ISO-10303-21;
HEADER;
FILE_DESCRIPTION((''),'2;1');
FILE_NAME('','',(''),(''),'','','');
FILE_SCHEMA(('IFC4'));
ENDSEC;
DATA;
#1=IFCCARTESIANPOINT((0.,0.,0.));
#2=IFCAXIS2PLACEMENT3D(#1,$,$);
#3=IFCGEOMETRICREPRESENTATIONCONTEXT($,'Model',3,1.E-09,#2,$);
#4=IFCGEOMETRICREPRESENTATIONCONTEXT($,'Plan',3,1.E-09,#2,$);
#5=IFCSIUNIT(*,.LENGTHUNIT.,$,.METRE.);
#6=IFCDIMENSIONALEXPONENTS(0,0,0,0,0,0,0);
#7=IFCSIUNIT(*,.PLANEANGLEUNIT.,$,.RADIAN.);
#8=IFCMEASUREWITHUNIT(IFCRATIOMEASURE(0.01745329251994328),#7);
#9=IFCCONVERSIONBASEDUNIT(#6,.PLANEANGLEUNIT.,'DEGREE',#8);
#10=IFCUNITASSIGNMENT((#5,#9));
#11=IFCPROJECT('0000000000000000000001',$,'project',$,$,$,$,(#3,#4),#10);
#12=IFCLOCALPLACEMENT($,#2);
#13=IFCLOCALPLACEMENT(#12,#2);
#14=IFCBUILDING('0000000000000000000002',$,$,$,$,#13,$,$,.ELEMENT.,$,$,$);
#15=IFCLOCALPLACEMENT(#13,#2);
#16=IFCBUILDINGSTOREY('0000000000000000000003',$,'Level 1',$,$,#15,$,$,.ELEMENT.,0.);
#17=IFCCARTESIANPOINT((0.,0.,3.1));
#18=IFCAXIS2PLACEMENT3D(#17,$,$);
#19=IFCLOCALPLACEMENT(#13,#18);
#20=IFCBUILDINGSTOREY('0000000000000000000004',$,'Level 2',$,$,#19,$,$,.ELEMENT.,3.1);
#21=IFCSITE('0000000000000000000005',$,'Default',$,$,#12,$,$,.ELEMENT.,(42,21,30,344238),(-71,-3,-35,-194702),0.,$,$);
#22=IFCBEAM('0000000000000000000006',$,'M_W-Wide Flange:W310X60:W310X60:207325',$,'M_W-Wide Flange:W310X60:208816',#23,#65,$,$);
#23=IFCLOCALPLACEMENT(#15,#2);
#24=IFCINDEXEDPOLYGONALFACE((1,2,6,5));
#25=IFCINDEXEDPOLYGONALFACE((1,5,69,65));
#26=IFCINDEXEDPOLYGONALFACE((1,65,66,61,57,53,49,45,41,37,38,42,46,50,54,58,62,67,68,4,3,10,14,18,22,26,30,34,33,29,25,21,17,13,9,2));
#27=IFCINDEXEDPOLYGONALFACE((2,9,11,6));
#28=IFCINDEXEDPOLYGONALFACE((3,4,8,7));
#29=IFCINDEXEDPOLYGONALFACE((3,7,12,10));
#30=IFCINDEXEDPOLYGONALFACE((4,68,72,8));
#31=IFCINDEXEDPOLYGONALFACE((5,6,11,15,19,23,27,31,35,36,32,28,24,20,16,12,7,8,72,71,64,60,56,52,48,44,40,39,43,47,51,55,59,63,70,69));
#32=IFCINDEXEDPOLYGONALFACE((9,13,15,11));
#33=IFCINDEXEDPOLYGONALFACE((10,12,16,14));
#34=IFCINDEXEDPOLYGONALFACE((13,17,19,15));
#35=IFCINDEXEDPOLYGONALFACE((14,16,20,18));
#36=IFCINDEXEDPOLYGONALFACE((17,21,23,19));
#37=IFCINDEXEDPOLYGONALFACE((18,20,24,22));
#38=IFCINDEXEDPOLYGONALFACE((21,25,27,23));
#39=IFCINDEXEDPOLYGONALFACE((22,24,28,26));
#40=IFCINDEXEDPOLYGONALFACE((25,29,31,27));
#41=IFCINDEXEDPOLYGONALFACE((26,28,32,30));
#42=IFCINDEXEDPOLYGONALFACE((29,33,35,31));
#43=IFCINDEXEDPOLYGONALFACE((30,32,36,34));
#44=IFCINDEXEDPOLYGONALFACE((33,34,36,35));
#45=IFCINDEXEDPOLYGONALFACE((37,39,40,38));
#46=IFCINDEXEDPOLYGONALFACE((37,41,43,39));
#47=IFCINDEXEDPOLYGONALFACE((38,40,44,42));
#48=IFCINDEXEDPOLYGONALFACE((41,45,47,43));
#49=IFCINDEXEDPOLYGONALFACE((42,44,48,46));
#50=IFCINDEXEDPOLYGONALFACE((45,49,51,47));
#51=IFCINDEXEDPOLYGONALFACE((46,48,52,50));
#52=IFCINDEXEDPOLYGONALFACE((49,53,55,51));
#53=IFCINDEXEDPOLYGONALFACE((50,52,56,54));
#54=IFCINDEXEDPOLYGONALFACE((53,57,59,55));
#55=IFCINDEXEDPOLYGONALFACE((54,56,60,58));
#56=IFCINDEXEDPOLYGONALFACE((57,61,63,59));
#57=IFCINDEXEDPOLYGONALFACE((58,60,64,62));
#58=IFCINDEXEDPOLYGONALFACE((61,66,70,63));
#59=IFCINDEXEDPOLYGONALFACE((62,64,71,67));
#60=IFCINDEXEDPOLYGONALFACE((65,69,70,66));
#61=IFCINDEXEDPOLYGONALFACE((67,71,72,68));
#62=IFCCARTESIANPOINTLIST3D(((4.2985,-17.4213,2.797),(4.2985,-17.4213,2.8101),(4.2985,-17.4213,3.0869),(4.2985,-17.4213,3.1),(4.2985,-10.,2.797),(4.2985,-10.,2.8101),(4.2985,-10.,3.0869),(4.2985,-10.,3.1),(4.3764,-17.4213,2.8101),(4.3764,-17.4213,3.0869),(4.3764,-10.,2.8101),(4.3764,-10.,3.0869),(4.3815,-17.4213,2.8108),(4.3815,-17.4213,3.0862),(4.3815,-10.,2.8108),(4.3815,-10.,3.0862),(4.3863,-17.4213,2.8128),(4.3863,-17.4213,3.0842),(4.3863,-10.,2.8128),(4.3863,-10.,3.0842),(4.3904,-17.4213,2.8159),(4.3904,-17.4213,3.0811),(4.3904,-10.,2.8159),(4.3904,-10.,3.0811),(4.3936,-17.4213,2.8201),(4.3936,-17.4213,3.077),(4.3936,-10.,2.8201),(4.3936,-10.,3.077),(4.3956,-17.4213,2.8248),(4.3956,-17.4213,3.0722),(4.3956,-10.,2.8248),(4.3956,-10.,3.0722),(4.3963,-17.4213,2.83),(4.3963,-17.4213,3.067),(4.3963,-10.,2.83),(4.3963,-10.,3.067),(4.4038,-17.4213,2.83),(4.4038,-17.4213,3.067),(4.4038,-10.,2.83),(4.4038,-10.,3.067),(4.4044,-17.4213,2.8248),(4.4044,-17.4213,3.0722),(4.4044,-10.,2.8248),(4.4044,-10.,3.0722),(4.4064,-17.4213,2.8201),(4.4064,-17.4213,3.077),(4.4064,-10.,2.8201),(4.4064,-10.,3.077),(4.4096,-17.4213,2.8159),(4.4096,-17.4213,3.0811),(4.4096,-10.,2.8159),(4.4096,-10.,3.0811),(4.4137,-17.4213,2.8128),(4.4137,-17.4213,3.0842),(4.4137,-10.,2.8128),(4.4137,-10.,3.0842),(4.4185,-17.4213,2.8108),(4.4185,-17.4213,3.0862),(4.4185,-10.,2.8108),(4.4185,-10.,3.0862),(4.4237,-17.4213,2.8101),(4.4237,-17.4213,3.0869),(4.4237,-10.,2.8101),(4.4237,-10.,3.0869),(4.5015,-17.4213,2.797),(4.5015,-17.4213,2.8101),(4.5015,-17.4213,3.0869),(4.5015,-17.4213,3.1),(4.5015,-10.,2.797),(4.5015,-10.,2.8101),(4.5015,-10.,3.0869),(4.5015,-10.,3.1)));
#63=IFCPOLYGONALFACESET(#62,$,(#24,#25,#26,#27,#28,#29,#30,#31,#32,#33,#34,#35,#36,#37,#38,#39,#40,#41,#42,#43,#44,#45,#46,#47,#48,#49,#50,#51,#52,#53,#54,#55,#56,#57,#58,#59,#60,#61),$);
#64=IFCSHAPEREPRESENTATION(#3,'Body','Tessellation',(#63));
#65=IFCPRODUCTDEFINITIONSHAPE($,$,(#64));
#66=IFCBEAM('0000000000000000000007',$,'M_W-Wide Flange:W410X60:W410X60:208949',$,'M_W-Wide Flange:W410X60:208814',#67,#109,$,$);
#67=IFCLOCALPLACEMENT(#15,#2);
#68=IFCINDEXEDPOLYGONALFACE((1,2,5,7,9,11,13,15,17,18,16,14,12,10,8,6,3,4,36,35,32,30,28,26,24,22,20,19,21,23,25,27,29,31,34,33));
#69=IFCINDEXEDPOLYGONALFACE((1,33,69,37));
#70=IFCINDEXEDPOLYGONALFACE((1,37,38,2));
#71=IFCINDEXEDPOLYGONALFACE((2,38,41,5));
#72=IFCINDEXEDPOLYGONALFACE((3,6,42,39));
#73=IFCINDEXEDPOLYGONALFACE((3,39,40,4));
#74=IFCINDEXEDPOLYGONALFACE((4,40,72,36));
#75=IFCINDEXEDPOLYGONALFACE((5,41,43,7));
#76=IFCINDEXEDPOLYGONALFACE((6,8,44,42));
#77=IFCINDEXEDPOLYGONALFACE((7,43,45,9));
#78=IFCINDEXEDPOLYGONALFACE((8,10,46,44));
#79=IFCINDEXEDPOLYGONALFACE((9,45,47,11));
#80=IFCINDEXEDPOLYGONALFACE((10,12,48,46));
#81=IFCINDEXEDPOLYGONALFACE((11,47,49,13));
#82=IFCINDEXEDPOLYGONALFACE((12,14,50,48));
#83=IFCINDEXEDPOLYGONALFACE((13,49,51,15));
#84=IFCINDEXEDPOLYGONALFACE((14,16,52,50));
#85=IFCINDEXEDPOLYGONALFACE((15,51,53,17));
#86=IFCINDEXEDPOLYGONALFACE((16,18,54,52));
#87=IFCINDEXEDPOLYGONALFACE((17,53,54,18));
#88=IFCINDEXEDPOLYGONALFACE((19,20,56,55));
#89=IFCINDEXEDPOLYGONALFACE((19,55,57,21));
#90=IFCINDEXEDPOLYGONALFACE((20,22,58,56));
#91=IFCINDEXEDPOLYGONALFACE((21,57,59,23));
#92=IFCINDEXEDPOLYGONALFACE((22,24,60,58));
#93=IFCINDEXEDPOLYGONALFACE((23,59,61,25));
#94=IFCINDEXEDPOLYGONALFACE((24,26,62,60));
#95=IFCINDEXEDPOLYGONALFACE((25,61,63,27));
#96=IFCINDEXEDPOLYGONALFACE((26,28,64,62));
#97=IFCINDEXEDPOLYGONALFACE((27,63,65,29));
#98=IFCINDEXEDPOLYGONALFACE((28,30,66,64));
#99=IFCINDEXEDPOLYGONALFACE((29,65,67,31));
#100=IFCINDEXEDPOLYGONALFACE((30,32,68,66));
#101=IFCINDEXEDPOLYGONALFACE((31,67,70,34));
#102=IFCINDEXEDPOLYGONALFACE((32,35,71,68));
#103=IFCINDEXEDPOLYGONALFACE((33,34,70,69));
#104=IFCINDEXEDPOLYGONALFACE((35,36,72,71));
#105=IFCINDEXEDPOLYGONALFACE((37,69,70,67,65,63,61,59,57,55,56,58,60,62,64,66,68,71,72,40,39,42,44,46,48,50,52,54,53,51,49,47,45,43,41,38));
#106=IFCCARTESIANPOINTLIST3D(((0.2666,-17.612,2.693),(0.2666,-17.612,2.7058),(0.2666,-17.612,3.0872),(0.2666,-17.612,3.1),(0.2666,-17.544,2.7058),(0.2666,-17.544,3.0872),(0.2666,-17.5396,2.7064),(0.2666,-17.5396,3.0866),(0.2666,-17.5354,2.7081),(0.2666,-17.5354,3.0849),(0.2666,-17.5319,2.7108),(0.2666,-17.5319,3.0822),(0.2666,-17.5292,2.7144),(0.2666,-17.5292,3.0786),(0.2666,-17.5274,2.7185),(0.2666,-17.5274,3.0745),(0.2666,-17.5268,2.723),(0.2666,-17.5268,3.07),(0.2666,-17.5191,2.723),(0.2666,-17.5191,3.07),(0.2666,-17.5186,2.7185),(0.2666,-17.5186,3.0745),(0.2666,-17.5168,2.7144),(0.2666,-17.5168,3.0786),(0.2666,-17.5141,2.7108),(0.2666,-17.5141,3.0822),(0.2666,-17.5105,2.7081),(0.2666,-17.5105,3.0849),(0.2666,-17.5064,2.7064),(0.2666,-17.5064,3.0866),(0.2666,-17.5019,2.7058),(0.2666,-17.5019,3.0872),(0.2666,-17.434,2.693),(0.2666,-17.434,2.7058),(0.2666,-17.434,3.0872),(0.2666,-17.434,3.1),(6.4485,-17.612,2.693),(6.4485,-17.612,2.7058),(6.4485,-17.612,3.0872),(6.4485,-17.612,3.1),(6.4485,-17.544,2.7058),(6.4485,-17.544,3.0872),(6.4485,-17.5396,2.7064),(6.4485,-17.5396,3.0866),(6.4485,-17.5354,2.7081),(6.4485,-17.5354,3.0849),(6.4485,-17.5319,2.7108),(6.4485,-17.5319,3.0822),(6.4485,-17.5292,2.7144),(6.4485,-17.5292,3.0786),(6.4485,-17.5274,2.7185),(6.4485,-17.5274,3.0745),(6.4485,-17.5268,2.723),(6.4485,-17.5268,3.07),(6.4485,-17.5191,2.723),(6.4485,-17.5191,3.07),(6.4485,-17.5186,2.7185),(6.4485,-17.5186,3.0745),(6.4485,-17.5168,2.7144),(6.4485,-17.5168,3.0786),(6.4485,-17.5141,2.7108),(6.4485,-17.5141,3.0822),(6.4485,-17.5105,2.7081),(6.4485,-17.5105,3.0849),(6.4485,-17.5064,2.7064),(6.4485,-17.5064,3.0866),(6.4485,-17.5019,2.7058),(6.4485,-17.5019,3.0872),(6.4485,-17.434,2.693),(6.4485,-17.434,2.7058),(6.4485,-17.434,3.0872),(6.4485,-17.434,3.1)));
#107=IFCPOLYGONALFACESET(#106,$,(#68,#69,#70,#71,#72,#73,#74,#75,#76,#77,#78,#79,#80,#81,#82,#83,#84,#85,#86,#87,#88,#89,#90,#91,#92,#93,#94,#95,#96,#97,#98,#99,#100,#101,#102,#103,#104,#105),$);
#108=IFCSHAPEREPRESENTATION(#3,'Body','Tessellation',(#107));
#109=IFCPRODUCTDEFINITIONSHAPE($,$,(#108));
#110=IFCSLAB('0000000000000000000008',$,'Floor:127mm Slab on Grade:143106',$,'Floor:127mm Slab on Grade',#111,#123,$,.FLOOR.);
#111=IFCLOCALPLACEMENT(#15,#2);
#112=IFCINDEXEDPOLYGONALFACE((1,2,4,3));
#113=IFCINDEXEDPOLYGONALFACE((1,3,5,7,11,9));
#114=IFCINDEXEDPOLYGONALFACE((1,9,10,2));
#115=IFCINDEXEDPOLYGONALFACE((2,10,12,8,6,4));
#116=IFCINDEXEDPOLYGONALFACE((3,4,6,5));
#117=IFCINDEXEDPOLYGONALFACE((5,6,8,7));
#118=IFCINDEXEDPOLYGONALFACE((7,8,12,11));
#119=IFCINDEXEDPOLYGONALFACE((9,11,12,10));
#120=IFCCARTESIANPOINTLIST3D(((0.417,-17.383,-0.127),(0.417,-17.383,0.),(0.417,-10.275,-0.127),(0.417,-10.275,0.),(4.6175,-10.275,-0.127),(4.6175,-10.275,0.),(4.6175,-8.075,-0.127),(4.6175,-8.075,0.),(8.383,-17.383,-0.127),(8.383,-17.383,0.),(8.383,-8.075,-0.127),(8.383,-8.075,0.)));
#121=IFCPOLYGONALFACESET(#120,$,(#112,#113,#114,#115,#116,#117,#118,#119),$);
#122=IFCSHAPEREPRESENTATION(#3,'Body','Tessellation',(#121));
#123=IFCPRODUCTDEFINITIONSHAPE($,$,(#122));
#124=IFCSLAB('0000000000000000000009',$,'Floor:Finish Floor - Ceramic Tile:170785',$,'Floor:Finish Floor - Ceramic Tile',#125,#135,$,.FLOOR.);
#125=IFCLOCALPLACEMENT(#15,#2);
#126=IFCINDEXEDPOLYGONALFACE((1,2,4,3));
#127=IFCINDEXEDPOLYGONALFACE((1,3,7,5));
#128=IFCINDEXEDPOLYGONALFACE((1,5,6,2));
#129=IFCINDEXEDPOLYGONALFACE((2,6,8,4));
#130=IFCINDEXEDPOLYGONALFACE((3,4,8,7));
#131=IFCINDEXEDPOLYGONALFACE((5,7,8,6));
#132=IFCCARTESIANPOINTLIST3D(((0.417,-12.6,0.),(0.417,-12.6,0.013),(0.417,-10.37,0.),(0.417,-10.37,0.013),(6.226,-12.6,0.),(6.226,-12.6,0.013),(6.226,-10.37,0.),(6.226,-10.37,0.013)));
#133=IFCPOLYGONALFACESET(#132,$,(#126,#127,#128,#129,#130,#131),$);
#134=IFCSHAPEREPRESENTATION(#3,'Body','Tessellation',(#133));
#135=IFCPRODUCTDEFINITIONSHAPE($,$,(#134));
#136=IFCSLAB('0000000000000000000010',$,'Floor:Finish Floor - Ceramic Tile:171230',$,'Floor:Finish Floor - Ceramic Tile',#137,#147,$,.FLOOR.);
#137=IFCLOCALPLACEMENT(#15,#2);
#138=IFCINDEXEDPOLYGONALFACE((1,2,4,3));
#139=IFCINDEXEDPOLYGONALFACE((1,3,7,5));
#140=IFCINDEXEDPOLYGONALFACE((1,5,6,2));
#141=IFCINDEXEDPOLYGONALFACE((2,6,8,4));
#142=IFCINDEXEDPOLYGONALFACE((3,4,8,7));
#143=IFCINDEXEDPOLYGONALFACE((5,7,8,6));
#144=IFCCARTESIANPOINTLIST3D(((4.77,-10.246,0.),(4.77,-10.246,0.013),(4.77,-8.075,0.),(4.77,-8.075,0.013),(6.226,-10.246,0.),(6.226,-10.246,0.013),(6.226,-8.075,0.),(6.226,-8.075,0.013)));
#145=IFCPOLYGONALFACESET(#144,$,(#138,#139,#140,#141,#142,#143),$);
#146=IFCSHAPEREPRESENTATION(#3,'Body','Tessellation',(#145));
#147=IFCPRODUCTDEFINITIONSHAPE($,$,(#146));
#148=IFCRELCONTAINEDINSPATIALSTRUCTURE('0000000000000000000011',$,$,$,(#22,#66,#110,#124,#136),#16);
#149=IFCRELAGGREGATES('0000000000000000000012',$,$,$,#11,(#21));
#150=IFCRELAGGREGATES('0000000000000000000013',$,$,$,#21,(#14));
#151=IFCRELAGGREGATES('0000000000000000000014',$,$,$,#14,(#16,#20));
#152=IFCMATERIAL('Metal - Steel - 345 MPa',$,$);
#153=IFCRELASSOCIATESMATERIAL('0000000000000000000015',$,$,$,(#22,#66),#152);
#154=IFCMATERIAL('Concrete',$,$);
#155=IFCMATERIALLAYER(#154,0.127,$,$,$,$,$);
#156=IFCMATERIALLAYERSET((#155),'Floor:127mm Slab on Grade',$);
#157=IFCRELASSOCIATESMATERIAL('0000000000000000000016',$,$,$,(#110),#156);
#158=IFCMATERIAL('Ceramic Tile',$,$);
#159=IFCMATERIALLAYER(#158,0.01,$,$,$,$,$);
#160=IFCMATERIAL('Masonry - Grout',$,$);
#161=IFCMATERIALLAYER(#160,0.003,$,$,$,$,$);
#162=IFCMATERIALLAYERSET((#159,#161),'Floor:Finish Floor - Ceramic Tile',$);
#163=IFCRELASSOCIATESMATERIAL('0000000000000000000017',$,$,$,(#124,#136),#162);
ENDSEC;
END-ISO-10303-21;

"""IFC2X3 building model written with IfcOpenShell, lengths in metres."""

from ifc_helpers import new_model, entity, si_unit, converted_unit, frame, frame_2d, origin, place, context, project, spatial, polyline, circle_curve, parameter, trimmed, segment, composite_curve, rectangle, outline, extrude, material, layer, layer_set, layer_usage, element, save


model = new_model("IFC2X3")

# Units and contexts
model_context = context("Model", 3, precision=1e-09, world=origin())
plan_context = context("Plan", 3, precision=1e-09, world=origin())
ifc_project = project(units=[si_unit("LENGTHUNIT", "METRE"), converted_unit("PLANEANGLEUNIT", "DEGREE", entity("IfcRatioMeasure", 0.01745329251994328), si_unit("PLANEANGLEUNIT", "RADIAN"), dimensions=[0, 0, 0, 0, 0, 0, 0])], contexts=[model_context, plan_context])

# Site, building, storey
site_placement = place(None, origin())
site = spatial("IfcSite", under=ifc_project, at=site_placement, Name="Default", CompositionType="ELEMENT", RefLatitude=(42, 21, 30, 344238), RefLongitude=(-71, -3, -35, -194702), RefElevation=0.0)
building_placement = place(site_placement, origin())
building = spatial("IfcBuilding", under=site, at=building_placement, CompositionType="ELEMENT")
storey_1_placement = place(building_placement, origin())
storey_1 = spatial("IfcBuildingStorey", under=building, at=storey_1_placement, Name="Level 1", CompositionType="ELEMENT", Elevation=0.0)

# Beams
ifc_material_1 = material(Name="Metal - Steel - 345 MPa")
beam_1_placement = place(storey_1_placement, frame((4.4, -10.0, 3.1), z_axis=(0.0, 0.0, 1.0), x_axis=(-1.0, 0.0, 0.0)))
element("IfcBeam", 1, at=beam_1_placement, inside=storey_1, material=ifc_material_1, Name="M_W-Wide Flange:W310X60:W310X60:207325", ObjectType="M_W-Wide Flange:W310X60:208816", context=model_context, shape_type="SweptSolid", body=[
    extrude(outline(composite_curve([segment(polyline([(0.1384, -0.1015), (0.1515, -0.1015)]), True, "CONTINUOUS"), segment(polyline([(0.1515, -0.1015), (0.1515, 0.1015)]), True, "CONTINUOUS"), segment(polyline([(0.1515, 0.1015), (0.1384, 0.1015)]), True, "CONTINUOUS"), segment(polyline([(0.1384, 0.1015), (0.1384, 0.0236)]), True, "CONTINUOUS"), segment(trimmed(circle_curve(frame_2d((0.1185, 0.0236), x_axis=(0.0, 1.0)), 0.0199), [parameter(180.0)], [parameter(270.0)], True, "PARAMETER"), False, "CONTINUOUS"), segment(polyline([(0.1185, 0.0037), (-0.1185, 0.0037)]), True, "CONTINUOUS"), segment(trimmed(circle_curve(frame_2d((-0.1185, 0.0236), x_axis=(0.0, 1.0)), 0.0199), [parameter(90.0)], [parameter(180.0)], True, "PARAMETER"), False, "CONTINUOUS"), segment(polyline([(-0.1384, 0.0236), (-0.1384, 0.1015)]), True, "CONTINUOUS"), segment(polyline([(-0.1384, 0.1015), (-0.1515, 0.1015)]), True, "CONTINUOUS"), segment(polyline([(-0.1515, 0.1015), (-0.1515, -0.1015)]), True, "CONTINUOUS"), segment(polyline([(-0.1515, -0.1015), (-0.1384, -0.1015)]), True, "CONTINUOUS"), segment(polyline([(-0.1384, -0.1015), (-0.1384, -0.0237)]), True, "CONTINUOUS"), segment(trimmed(circle_curve(frame_2d((-0.1185, -0.0237), x_axis=(0.0, 1.0)), 0.0199), [parameter(360.0)], [parameter(90.0)], True, "PARAMETER"), False, "CONTINUOUS"), segment(polyline([(-0.1185, -0.0038), (0.1185, -0.0038)]), True, "CONTINUOUS"), segment(trimmed(circle_curve(frame_2d((0.1185, -0.0237), x_axis=(0.0, 1.0)), 0.0199), [parameter(270.0)], [parameter(0.0)], True, "PARAMETER"), False, "CONTINUOUS"), segment(polyline([(0.1384, -0.0237), (0.1384, -0.1015)]), True, "CONTINUOUS")], self_intersect=False)), frame((0.0, 7.4213, -0.1515), z_axis=(0.0, -1.0, 0.0), x_axis=(0.0, 0.0, -1.0)), (0.0, 0.0, 1.0), 7.4213),
])
beam_2_placement = place(storey_1_placement, frame((0.2085, -17.523, 3.1), z_axis=(0.0, 0.0, 1.0), x_axis=(0.0, -1.0, 0.0)))
element("IfcBeam", 2, at=beam_2_placement, inside=storey_1, material=ifc_material_1, Name="M_W-Wide Flange:W410X60:W410X60:208949", ObjectType="M_W-Wide Flange:W410X60:208814", context=model_context, shape_type="SweptSolid", body=[
    extrude(outline(composite_curve([segment(polyline([(-0.089, -0.1907), (-0.089, -0.2035)]), True, "CONTINUOUS"), segment(polyline([(-0.089, -0.2035), (0.089, -0.2035)]), True, "CONTINUOUS"), segment(polyline([(0.089, -0.2035), (0.089, -0.1907)]), True, "CONTINUOUS"), segment(polyline([(0.089, -0.1907), (0.021, -0.1907)]), True, "CONTINUOUS"), segment(trimmed(circle_curve(frame_2d((0.021, -0.1735), x_axis=(0.0, -1.0)), 0.0172), [parameter(270.0)], [parameter(360.0)], True, "PARAMETER"), False, "CONTINUOUS"), segment(polyline([(0.0038, -0.1735), (0.0038, 0.1735)]), True, "CONTINUOUS"), segment(trimmed(circle_curve(frame_2d((0.021, 0.1735), x_axis=(-1.0, 0.0)), 0.0172), [parameter(270.0)], [parameter(360.0)], True, "PARAMETER"), False, "CONTINUOUS"), segment(polyline([(0.021, 0.1907), (0.089, 0.1907)]), True, "CONTINUOUS"), segment(polyline([(0.089, 0.1907), (0.089, 0.2035)]), True, "CONTINUOUS"), segment(polyline([(0.089, 0.2035), (-0.089, 0.2035)]), True, "CONTINUOUS"), segment(polyline([(-0.089, 0.2035), (-0.089, 0.1907)]), True, "CONTINUOUS"), segment(polyline([(-0.089, 0.1907), (-0.0211, 0.1907)]), True, "CONTINUOUS"), segment(trimmed(circle_curve(frame_2d((-0.0211, 0.1735), x_axis=(0.0, 1.0)), 0.0172), [parameter(270.0)], [parameter(0.0)], True, "PARAMETER"), False, "CONTINUOUS"), segment(polyline([(-0.0039, 0.1735), (-0.0039, -0.1735)]), True, "CONTINUOUS"), segment(trimmed(circle_curve(frame_2d((-0.0211, -0.1735), x_axis=(1.0, 0.0)), 0.0172), [parameter(270.0)], [parameter(0.0)], True, "PARAMETER"), False, "CONTINUOUS"), segment(polyline([(-0.0211, -0.1907), (-0.089, -0.1907)]), True, "CONTINUOUS")], self_intersect=False)), frame((0.0, 0.0581, -0.2035), z_axis=(0.0, -1.0, 0.0), x_axis=(1.0, 0.0, 0.0)), (0.0, 0.0, -1.0), 6.1819),
])

# Slabs
ifc_material_2 = material(Name="Concrete")
ifc_layer_1 = layer(ifc_material_2, 0.127)
ifc_layer_set_1 = layer_set([ifc_layer_1], Name="Floor:127mm Slab on Grade")
ifc_layer_usage_1 = layer_usage(ifc_layer_set_1, "AXIS3", "POSITIVE", 0.0)
slab_1_placement = place(storey_1_placement, frame((0.417, -17.383, -0.127)))
element("IfcSlab", 3, at=slab_1_placement, inside=storey_1, material=ifc_layer_usage_1, Name="Floor:127mm Slab on Grade:143106", ObjectType="Floor:127mm Slab on Grade", PredefinedType="FLOOR", context=model_context, shape_type="SweptSolid", body=[
    extrude(outline(polyline([(-3.983, 4.654), (-3.983, -4.654), (3.983, -4.654), (3.983, 2.454), (-0.2175, 2.454), (-0.2175, 4.654), (-3.983, 4.654)])), frame((3.983, 4.654, 0.127), z_axis=(0.0, 0.0, -1.0), x_axis=(-1.0, 0.0, 0.0)), (0.0, 0.0, 1.0), 0.127),
])
ifc_material_3 = material(Name="Ceramic Tile")
ifc_layer_2 = layer(ifc_material_3, 0.01)
ifc_material_4 = material(Name="Masonry - Grout")
ifc_layer_3 = layer(ifc_material_4, 0.003)
ifc_layer_set_2 = layer_set([ifc_layer_2, ifc_layer_3], Name="Floor:Finish Floor - Ceramic Tile")
ifc_layer_usage_2 = layer_usage(ifc_layer_set_2, "AXIS3", "POSITIVE", 0.0)
slab_2_placement = place(storey_1_placement, frame((0.417, -12.6, 0.0)))
element("IfcSlab", 4, at=slab_2_placement, inside=storey_1, material=ifc_layer_usage_2, Name="Floor:Finish Floor - Ceramic Tile:170785", ObjectType="Floor:Finish Floor - Ceramic Tile", PredefinedType="FLOOR", context=model_context, shape_type="SweptSolid", body=[
    extrude(rectangle(XDim=5.809, YDim=2.23, at=frame_2d((0.0, 0.0), x_axis=(-1.0, 0.0))), frame((2.9045, 1.115, 0.013), z_axis=(0.0, 0.0, -1.0), x_axis=(-1.0, 0.0, 0.0)), (0.0, 0.0, 1.0), 0.013),
])
ifc_layer_usage_3 = layer_usage(ifc_layer_set_2, "AXIS3", "POSITIVE", 0.0)
slab_3_placement = place(storey_1_placement, frame((4.77, -10.246, 0.0)))
element("IfcSlab", 5, at=slab_3_placement, inside=storey_1, material=ifc_layer_usage_3, Name="Floor:Finish Floor - Ceramic Tile:171230", ObjectType="Floor:Finish Floor - Ceramic Tile", PredefinedType="FLOOR", context=model_context, shape_type="SweptSolid", body=[
    extrude(rectangle(XDim=1.456, YDim=2.171, at=frame_2d((0.0, 0.0), x_axis=(-1.0, 0.0))), frame((0.728, 1.0855, 0.013), z_axis=(0.0, 0.0, -1.0), x_axis=(-1.0, 0.0, 0.0)), (0.0, 0.0, 1.0), 0.013),
])

# Shared definitions
storey_2_placement = place(building_placement, frame((0.0, 0.0, 3.1)))
storey_2 = spatial("IfcBuildingStorey", under=building, at=storey_2_placement, Name="Level 2", CompositionType="ELEMENT", Elevation=3.1)

save(model, "model.ifc")
